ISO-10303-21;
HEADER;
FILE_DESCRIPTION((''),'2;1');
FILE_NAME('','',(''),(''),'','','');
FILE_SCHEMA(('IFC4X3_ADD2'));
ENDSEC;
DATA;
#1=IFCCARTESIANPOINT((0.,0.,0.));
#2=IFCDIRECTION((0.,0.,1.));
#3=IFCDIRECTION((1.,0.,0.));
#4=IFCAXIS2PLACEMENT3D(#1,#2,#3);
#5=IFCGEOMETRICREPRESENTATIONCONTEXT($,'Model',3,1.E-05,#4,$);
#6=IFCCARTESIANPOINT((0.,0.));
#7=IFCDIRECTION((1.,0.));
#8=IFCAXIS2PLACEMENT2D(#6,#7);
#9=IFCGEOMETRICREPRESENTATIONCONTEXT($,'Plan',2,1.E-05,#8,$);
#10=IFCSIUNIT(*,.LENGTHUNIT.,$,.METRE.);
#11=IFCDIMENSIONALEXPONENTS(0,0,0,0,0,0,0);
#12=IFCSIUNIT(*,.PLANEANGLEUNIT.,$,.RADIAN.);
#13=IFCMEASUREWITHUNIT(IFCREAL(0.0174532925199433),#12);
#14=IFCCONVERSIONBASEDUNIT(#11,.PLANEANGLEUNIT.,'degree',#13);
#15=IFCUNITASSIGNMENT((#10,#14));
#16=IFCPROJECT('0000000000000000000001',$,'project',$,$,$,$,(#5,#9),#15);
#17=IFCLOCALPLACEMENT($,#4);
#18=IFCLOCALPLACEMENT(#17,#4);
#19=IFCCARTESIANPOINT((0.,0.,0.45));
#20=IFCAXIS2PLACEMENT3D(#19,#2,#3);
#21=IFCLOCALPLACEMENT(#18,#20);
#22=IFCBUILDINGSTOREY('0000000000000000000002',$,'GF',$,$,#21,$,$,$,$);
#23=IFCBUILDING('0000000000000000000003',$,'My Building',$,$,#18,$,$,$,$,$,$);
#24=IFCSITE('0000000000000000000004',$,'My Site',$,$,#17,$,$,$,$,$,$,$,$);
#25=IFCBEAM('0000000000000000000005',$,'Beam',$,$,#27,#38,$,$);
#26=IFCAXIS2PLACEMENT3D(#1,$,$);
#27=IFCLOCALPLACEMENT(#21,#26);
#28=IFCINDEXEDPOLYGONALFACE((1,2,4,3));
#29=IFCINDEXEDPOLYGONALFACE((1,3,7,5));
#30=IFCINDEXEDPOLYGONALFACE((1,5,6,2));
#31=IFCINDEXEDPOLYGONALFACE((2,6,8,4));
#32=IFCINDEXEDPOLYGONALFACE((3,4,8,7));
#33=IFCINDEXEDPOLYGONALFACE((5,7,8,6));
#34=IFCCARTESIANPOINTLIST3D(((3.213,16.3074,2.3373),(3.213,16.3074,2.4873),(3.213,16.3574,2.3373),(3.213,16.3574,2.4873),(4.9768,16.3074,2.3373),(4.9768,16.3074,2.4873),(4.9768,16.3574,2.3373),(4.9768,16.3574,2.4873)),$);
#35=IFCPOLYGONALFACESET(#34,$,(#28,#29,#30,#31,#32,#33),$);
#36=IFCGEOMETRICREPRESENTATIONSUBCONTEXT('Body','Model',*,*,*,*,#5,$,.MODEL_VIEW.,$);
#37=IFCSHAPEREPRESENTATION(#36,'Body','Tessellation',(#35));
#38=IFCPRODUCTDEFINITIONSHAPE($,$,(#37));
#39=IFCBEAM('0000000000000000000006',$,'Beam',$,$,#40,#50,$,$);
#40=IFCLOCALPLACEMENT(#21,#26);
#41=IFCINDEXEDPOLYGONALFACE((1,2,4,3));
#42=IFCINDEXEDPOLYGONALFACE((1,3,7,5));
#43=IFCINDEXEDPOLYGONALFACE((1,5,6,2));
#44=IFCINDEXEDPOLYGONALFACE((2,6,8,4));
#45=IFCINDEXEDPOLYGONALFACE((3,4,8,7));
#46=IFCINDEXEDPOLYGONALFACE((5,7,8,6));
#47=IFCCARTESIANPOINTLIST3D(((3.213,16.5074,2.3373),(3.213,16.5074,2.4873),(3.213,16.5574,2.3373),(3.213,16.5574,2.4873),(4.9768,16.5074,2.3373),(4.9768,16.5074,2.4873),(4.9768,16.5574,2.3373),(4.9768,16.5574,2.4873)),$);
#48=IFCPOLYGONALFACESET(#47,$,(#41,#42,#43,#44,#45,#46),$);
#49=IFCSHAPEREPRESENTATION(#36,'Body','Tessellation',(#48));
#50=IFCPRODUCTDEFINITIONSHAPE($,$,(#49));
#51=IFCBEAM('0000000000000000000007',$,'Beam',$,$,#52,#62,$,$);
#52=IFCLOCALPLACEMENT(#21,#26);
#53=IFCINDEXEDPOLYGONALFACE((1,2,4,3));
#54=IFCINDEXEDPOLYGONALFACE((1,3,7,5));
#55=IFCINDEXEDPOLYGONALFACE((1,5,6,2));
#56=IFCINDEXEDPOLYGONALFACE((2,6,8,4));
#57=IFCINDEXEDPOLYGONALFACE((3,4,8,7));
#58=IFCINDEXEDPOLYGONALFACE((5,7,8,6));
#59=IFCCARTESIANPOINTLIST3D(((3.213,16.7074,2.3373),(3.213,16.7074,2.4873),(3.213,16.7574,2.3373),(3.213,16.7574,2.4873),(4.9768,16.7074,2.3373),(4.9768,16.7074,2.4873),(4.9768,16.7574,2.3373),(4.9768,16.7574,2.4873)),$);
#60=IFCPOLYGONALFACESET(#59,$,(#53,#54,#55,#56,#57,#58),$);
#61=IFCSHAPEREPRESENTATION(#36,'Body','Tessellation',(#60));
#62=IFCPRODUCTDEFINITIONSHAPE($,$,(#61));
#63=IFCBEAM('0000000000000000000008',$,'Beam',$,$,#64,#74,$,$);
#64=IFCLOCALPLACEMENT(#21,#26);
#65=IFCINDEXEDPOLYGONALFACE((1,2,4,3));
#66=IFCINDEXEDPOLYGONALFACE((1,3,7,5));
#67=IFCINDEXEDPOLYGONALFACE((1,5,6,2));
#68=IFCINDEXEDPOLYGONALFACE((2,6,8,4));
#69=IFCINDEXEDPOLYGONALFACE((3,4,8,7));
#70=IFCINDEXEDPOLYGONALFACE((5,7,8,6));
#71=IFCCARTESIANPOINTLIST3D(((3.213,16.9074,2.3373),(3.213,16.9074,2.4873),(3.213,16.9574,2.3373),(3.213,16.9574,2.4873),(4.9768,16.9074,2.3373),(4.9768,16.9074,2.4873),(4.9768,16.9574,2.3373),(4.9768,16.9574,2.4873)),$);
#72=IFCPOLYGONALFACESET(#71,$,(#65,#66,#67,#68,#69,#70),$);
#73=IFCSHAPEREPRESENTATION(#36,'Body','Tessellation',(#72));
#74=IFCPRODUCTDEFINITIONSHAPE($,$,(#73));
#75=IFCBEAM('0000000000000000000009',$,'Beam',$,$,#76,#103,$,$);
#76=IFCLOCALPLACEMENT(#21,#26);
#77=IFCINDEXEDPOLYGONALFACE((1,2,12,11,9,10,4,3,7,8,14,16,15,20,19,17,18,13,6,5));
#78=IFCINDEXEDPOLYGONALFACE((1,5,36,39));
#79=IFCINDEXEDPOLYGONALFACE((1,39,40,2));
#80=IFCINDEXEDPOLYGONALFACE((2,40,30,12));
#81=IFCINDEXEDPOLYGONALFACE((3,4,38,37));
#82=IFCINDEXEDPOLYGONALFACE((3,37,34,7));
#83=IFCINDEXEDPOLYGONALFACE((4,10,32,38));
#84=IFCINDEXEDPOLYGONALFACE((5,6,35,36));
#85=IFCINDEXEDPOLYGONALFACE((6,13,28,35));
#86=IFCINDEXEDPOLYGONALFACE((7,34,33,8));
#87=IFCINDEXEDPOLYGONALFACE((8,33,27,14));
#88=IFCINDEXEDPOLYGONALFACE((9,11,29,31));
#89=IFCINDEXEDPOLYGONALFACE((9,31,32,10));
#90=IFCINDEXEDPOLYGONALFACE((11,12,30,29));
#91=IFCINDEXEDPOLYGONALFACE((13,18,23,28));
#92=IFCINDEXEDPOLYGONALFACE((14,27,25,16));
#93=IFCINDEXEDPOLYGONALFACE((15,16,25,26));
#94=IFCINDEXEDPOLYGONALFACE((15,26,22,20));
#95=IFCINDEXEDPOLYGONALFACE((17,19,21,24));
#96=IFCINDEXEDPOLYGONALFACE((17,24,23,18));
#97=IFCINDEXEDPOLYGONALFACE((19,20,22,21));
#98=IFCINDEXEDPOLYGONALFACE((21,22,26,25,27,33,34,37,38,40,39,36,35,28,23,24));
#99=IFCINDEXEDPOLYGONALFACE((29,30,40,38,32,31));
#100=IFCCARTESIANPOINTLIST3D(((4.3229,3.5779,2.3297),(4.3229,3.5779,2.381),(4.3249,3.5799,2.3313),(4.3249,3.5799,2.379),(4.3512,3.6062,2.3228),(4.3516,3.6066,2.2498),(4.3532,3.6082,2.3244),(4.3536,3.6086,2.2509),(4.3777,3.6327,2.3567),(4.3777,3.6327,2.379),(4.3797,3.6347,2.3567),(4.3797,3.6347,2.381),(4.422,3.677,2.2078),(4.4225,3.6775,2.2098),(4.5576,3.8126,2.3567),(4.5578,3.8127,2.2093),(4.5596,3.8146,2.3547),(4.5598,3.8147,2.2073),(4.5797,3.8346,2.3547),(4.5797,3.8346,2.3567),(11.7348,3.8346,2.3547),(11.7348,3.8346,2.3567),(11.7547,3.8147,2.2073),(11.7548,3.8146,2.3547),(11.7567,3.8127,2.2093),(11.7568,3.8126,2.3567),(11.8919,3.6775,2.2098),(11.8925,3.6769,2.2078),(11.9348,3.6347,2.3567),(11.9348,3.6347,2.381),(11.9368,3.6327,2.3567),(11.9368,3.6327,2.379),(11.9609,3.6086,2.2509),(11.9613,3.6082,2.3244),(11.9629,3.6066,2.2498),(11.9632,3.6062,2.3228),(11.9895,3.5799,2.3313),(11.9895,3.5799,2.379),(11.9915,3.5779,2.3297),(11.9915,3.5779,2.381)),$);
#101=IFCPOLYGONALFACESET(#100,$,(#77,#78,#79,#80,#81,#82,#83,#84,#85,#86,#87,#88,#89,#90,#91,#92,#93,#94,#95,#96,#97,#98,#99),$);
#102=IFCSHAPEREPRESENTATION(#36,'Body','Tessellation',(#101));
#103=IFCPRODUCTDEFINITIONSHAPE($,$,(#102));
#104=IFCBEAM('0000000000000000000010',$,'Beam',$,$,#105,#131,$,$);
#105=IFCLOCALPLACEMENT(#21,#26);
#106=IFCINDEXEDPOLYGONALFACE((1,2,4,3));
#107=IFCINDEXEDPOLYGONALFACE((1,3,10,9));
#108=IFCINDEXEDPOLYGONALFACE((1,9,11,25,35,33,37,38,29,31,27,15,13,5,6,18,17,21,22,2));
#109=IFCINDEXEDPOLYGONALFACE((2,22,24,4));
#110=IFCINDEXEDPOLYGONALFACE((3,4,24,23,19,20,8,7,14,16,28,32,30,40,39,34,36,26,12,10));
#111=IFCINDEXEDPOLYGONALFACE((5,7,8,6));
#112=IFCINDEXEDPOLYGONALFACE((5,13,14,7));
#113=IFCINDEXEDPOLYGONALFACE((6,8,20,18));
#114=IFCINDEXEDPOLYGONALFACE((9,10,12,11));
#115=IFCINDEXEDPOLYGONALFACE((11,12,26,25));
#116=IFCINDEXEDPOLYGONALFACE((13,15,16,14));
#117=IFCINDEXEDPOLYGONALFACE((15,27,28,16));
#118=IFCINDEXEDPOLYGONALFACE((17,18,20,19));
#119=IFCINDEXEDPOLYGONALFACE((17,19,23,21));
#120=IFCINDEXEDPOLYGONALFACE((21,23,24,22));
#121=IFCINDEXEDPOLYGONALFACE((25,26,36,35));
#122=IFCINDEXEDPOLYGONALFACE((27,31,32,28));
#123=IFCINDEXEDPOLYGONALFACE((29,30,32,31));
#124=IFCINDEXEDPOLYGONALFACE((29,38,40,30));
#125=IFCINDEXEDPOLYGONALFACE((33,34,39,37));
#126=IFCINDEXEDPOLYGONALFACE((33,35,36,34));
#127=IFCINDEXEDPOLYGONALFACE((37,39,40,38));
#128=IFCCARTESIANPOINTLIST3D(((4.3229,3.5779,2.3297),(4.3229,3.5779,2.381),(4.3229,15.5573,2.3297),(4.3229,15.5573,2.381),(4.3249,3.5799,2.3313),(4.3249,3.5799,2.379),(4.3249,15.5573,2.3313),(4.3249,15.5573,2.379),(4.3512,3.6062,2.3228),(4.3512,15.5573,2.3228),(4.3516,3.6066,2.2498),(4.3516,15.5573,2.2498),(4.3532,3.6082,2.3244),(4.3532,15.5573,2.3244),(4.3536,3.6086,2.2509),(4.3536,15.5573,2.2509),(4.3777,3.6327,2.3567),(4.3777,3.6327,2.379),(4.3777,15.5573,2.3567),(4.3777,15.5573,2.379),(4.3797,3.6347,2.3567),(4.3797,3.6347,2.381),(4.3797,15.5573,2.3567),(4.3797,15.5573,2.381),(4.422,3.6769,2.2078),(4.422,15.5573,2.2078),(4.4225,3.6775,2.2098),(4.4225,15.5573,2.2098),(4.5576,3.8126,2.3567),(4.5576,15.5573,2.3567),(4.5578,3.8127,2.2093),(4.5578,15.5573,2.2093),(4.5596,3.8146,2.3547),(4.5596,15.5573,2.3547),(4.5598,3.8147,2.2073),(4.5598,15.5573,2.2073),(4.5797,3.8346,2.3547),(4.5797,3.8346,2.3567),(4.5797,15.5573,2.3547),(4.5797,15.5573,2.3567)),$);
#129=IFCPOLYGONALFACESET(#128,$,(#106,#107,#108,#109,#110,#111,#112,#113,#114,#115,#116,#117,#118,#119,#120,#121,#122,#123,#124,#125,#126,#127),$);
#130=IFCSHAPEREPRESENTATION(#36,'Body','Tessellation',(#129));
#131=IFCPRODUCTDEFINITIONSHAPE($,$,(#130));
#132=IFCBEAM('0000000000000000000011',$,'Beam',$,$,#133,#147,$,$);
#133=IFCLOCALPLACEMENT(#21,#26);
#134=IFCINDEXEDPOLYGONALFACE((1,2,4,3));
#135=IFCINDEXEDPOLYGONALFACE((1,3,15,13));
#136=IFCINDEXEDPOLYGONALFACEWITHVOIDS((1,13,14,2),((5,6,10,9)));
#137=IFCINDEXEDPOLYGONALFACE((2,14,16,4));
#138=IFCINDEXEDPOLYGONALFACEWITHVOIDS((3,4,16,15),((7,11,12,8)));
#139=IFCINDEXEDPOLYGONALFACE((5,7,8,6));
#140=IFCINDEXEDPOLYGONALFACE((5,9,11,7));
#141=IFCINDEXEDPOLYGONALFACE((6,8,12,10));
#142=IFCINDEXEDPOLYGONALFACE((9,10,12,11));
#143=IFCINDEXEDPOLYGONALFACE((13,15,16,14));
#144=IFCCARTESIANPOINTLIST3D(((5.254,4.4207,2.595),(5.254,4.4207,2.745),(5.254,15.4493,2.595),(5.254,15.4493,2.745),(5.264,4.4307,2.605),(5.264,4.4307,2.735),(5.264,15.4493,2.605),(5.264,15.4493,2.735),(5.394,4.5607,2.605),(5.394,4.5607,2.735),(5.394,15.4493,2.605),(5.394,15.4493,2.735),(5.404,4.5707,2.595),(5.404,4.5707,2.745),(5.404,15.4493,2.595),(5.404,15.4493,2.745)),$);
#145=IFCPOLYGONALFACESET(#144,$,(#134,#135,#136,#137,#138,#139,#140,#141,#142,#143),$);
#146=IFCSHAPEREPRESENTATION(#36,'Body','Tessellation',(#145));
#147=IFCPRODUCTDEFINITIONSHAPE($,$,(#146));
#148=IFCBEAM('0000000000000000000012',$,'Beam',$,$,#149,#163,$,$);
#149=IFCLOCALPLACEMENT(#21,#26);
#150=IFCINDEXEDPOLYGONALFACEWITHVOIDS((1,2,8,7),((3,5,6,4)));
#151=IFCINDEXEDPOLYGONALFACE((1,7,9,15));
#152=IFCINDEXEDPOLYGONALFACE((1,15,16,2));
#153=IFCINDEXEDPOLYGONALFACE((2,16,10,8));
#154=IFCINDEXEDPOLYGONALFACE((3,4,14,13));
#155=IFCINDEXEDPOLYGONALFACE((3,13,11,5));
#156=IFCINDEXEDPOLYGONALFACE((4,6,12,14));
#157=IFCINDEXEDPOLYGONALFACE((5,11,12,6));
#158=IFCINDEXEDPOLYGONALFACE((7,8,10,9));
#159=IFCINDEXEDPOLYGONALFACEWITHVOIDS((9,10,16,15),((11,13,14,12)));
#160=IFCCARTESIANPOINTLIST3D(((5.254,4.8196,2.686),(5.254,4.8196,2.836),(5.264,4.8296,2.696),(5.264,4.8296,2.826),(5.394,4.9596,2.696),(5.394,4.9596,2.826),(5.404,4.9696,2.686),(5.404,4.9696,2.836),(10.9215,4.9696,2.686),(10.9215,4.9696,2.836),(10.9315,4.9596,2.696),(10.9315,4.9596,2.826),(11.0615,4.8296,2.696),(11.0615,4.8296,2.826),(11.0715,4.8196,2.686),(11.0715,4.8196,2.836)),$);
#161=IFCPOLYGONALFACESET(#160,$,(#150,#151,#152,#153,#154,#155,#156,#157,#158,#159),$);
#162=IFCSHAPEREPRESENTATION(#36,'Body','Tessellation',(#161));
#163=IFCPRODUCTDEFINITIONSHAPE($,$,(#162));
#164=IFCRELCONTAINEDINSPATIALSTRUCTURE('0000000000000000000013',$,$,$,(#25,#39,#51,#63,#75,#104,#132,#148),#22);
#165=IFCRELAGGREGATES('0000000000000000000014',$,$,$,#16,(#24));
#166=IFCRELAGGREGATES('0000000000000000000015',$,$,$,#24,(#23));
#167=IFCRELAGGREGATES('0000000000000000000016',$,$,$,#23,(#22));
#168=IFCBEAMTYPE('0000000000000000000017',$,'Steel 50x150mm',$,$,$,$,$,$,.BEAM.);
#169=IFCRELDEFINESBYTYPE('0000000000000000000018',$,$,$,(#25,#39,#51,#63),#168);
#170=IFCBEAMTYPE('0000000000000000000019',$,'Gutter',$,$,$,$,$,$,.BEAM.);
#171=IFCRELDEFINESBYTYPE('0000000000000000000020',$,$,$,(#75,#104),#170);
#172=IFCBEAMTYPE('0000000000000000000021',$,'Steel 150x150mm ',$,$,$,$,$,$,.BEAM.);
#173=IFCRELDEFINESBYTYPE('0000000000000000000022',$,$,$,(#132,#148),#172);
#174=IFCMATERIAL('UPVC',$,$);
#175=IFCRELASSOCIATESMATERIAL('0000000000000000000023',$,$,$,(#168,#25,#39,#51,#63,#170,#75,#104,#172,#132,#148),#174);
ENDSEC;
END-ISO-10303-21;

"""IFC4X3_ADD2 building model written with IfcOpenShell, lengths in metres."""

from ifc_helpers import new_model, entity, si_unit, converted_unit, frame, origin_with_axes, origin_2d_with_axis, place, context, subcontext, project, spatial, indexed_curve, rectangle, hollow_rectangle, outline, extrude, clip, halfspace, material, material_profile, profile_set, profile_usage, type_object, element, save


model = new_model("IFC4X3_ADD2")

# Units and contexts
model_context = context("Model", 3, precision=1e-05, world=origin_with_axes())
plan_context = context("Plan", 2, precision=1e-05, world=origin_2d_with_axis())
body_context_1 = subcontext(model_context, "Body", "Model", "MODEL_VIEW")
ifc_project = project(units=[si_unit("LENGTHUNIT", "METRE"), converted_unit("PLANEANGLEUNIT", "degree", entity("IfcReal", 0.0174532925199433), si_unit("PLANEANGLEUNIT", "RADIAN"), dimensions=[0, 0, 0, 0, 0, 0, 0])], contexts=[model_context, plan_context])

# Site, building, storey
site_placement = place(None, origin_with_axes())
site = spatial("IfcSite", under=ifc_project, at=site_placement, Name="My Site")
building_placement = place(site_placement, origin_with_axes())
building = spatial("IfcBuilding", under=site, at=building_placement, Name="My Building")
storey_placement = place(building_placement, frame((0.0, 0.0, 0.45), z_axis=(0.0, 0.0, 1.0), x_axis=(1.0, 0.0, 0.0)))
storey = spatial("IfcBuildingStorey", under=building, at=storey_placement, Name="GF")

# Beams
ifc_material_1 = material(Name="UPVC")
ifc_material_profile_1 = material_profile(ifc_material_1, rectangle(XDim=0.05, YDim=0.15))
ifc_profile_set_1 = profile_set([ifc_material_profile_1])
beam_type_1 = type_object("IfcBeamType", Name="Steel 50x150mm", PredefinedType="BEAM", material=ifc_profile_set_1)
ifc_profile_usage_1 = profile_usage(ifc_profile_set_1)
beam_1_placement = place(storey_placement, frame((3.213, 16.3324, 2.4123), z_axis=(1.0, 0.0, 0.0), x_axis=(0.0, 1.0, 0.0)))
element("IfcBeam", 1, at=beam_1_placement, inside=storey, type_object=beam_type_1, material=ifc_profile_usage_1, Name="Beam", context=body_context_1, shape_type="SweptSolid", body=[
    extrude(rectangle(XDim=0.05, YDim=0.15), origin_with_axes(), (0.0, 0.0, 1.0), 1.7638),
])
ifc_profile_usage_2 = profile_usage(ifc_profile_set_1)
beam_2_placement = place(storey_placement, frame((3.213, 16.5324, 2.4123), z_axis=(1.0, 0.0, 0.0), x_axis=(0.0, 1.0, 0.0)))
element("IfcBeam", 2, at=beam_2_placement, inside=storey, type_object=beam_type_1, material=ifc_profile_usage_2, Name="Beam", context=body_context_1, shape_type="SweptSolid", body=[
    extrude(rectangle(XDim=0.05, YDim=0.15), origin_with_axes(), (0.0, 0.0, 1.0), 1.7638),
])
ifc_profile_usage_3 = profile_usage(ifc_profile_set_1)
beam_3_placement = place(storey_placement, frame((3.213, 16.7324, 2.4123), z_axis=(1.0, 0.0, 0.0), x_axis=(0.0, 1.0, 0.0)))
element("IfcBeam", 3, at=beam_3_placement, inside=storey, type_object=beam_type_1, material=ifc_profile_usage_3, Name="Beam", context=body_context_1, shape_type="SweptSolid", body=[
    extrude(rectangle(XDim=0.05, YDim=0.15), origin_with_axes(), (0.0, 0.0, 1.0), 1.7638),
])
ifc_profile_usage_4 = profile_usage(ifc_profile_set_1)
beam_4_placement = place(storey_placement, frame((3.213, 16.9324, 2.4123), z_axis=(1.0, 0.0, 0.0), x_axis=(0.0, 1.0, 0.0)))
element("IfcBeam", 4, at=beam_4_placement, inside=storey, type_object=beam_type_1, material=ifc_profile_usage_4, Name="Beam", context=body_context_1, shape_type="SweptSolid", body=[
    extrude(rectangle(XDim=0.05, YDim=0.15), origin_with_axes(), (0.0, 0.0, 1.0), 1.7638),
])
ifc_material_profile_2 = material_profile(ifc_material_1, outline(indexed_curve([(0.0548, 0.1717), (0.002, 0.1717), (0.002, 0.124), (0.0303, 0.1171), (0.0307, 0.0436), (0.0996, 0.0025), (0.2349, 0.002), (0.2347, 0.1494), (0.2567, 0.1494), (0.2567, 0.1474), (0.2367, 0.1474), (0.2369, 0.0), (0.0991, 0.0005), (0.0287, 0.0425), (0.0283, 0.1155), (0.0, 0.1224), (0.0, 0.1737), (0.0568, 0.1737), (0.0568, 0.1494), (0.0548, 0.1494), (0.0548, 0.1717)])))
ifc_profile_set_2 = profile_set([ifc_material_profile_2])
ifc_profile_usage_5 = profile_usage(ifc_profile_set_2, cardinal=5)
beam_type_2 = type_object("IfcBeamType", Name="Gutter", PredefinedType="BEAM", material=ifc_profile_set_2)
beam_5_placement = place(storey_placement, frame((4.3229, 3.5779, 2.2073), z_axis=(1.0, 0.0, 0.0), x_axis=(0.0, 1.0, 0.0)))
element("IfcBeam", 5, at=beam_5_placement, inside=storey, type_object=beam_type_2, material=ifc_profile_usage_5, Name="Beam", context=body_context_1, shape_type="Clipping", body=[
    clip(clip(extrude(outline(indexed_curve([(0.0548, 0.1717), (0.002, 0.1717), (0.002, 0.124), (0.0303, 0.1171), (0.0307, 0.0436), (0.0996, 0.0025), (0.2349, 0.002), (0.2347, 0.1494), (0.2567, 0.1494), (0.2567, 0.1474), (0.2367, 0.1474), (0.2369, 0.0), (0.0991, 0.0005), (0.0287, 0.0425), (0.0283, 0.1155), (0.0, 0.1224), (0.0, 0.1737), (0.0568, 0.1737), (0.0568, 0.1494), (0.0548, 0.1494), (0.0548, 0.1717)])), origin_with_axes(), (0.0, 0.0, 1.0), 7.6686), halfspace(frame((0.0, -2.6573, 0.0), z_axis=(0.707107, 0.0, -0.707107), x_axis=(0.0, -1.0, 0.0)), False)), halfspace(frame((0.0, -2.6573, 7.6686), z_axis=(0.707107, 0.0, 0.707107), x_axis=(0.0, -1.0, 0.0)), False)),
])
ifc_profile_usage_6 = profile_usage(ifc_profile_set_2, cardinal=5)
beam_6_placement = place(storey_placement, frame((4.3229, 15.5573, 2.2073), z_axis=(0.0, -1.0, 0.0), x_axis=(1.0, 0.0, 0.0)))
element("IfcBeam", 6, at=beam_6_placement, inside=storey, type_object=beam_type_2, material=ifc_profile_usage_6, Name="Beam", context=body_context_1, shape_type="Clipping", body=[
    clip(extrude(outline(indexed_curve([(0.0548, 0.1717), (0.002, 0.1717), (0.002, 0.124), (0.0303, 0.1171), (0.0307, 0.0436), (0.0996, 0.0025), (0.2349, 0.002), (0.2347, 0.1494), (0.2567, 0.1494), (0.2567, 0.1474), (0.2367, 0.1474), (0.2369, 0.0), (0.0991, 0.0005), (0.0287, 0.0425), (0.0283, 0.1155), (0.0, 0.1224), (0.0, 0.1737), (0.0568, 0.1737), (0.0568, 0.1494), (0.0548, 0.1494), (0.0548, 0.1717)])), origin_with_axes(), (0.0, 0.0, 1.0), 11.9794), halfspace(frame((0.0, -2.8276, 11.9794), z_axis=(0.707107, 0.0, 0.707107), x_axis=(0.0, -1.0, 0.0)), False)),
])
ifc_material_profile_3 = material_profile(ifc_material_1, hollow_rectangle(XDim=0.15, YDim=0.15, WallThickness=0.01))
ifc_profile_set_3 = profile_set([ifc_material_profile_3])
ifc_profile_usage_7 = profile_usage(ifc_profile_set_3)
beam_type_3 = type_object("IfcBeamType", Name="Steel 150x150mm ", PredefinedType="BEAM", material=ifc_profile_set_3)
beam_7_placement = place(storey_placement, frame((5.329, 4.4207, 2.67), z_axis=(0.0, 1.0, 0.0), x_axis=(-1.0, 0.0, 0.0)))
element("IfcBeam", 7, at=beam_7_placement, inside=storey, type_object=beam_type_3, material=ifc_profile_usage_7, Name="Beam", context=body_context_1, shape_type="Clipping", body=[
    clip(extrude(hollow_rectangle(XDim=0.15, YDim=0.15, WallThickness=0.01), origin_with_axes(), (0.0, 0.0, 1.0), 11.0287), halfspace(frame((0.075, -3.466, 0.0), z_axis=(-0.707107, 0.0, -0.707107), x_axis=(0.0, 1.0, 0.0)), False)),
])
ifc_profile_usage_8 = profile_usage(ifc_profile_set_3)
beam_8_placement = place(storey_placement, frame((5.254, 4.8946, 2.761), z_axis=(1.0, 0.0, 0.0), x_axis=(0.0, 1.0, 0.0)))
element("IfcBeam", 8, at=beam_8_placement, inside=storey, type_object=beam_type_3, material=ifc_profile_usage_8, Name="Beam", context=body_context_1, shape_type="Clipping", body=[
    clip(clip(extrude(hollow_rectangle(XDim=0.15, YDim=0.15, WallThickness=0.01), origin_with_axes(), (0.0, 0.0, 1.0), 5.8174), halfspace(frame((-0.075, -3.211, 5.8174), z_axis=(0.707107, 0.0, 0.707107), x_axis=(0.0, -1.0, 0.0)), False)), halfspace(frame((-0.075, -3.211, 0.0), z_axis=(0.707107, 0.0, -0.707107), x_axis=(0.0, -1.0, 0.0)), False)),
])

save(model, "model.ifc")
